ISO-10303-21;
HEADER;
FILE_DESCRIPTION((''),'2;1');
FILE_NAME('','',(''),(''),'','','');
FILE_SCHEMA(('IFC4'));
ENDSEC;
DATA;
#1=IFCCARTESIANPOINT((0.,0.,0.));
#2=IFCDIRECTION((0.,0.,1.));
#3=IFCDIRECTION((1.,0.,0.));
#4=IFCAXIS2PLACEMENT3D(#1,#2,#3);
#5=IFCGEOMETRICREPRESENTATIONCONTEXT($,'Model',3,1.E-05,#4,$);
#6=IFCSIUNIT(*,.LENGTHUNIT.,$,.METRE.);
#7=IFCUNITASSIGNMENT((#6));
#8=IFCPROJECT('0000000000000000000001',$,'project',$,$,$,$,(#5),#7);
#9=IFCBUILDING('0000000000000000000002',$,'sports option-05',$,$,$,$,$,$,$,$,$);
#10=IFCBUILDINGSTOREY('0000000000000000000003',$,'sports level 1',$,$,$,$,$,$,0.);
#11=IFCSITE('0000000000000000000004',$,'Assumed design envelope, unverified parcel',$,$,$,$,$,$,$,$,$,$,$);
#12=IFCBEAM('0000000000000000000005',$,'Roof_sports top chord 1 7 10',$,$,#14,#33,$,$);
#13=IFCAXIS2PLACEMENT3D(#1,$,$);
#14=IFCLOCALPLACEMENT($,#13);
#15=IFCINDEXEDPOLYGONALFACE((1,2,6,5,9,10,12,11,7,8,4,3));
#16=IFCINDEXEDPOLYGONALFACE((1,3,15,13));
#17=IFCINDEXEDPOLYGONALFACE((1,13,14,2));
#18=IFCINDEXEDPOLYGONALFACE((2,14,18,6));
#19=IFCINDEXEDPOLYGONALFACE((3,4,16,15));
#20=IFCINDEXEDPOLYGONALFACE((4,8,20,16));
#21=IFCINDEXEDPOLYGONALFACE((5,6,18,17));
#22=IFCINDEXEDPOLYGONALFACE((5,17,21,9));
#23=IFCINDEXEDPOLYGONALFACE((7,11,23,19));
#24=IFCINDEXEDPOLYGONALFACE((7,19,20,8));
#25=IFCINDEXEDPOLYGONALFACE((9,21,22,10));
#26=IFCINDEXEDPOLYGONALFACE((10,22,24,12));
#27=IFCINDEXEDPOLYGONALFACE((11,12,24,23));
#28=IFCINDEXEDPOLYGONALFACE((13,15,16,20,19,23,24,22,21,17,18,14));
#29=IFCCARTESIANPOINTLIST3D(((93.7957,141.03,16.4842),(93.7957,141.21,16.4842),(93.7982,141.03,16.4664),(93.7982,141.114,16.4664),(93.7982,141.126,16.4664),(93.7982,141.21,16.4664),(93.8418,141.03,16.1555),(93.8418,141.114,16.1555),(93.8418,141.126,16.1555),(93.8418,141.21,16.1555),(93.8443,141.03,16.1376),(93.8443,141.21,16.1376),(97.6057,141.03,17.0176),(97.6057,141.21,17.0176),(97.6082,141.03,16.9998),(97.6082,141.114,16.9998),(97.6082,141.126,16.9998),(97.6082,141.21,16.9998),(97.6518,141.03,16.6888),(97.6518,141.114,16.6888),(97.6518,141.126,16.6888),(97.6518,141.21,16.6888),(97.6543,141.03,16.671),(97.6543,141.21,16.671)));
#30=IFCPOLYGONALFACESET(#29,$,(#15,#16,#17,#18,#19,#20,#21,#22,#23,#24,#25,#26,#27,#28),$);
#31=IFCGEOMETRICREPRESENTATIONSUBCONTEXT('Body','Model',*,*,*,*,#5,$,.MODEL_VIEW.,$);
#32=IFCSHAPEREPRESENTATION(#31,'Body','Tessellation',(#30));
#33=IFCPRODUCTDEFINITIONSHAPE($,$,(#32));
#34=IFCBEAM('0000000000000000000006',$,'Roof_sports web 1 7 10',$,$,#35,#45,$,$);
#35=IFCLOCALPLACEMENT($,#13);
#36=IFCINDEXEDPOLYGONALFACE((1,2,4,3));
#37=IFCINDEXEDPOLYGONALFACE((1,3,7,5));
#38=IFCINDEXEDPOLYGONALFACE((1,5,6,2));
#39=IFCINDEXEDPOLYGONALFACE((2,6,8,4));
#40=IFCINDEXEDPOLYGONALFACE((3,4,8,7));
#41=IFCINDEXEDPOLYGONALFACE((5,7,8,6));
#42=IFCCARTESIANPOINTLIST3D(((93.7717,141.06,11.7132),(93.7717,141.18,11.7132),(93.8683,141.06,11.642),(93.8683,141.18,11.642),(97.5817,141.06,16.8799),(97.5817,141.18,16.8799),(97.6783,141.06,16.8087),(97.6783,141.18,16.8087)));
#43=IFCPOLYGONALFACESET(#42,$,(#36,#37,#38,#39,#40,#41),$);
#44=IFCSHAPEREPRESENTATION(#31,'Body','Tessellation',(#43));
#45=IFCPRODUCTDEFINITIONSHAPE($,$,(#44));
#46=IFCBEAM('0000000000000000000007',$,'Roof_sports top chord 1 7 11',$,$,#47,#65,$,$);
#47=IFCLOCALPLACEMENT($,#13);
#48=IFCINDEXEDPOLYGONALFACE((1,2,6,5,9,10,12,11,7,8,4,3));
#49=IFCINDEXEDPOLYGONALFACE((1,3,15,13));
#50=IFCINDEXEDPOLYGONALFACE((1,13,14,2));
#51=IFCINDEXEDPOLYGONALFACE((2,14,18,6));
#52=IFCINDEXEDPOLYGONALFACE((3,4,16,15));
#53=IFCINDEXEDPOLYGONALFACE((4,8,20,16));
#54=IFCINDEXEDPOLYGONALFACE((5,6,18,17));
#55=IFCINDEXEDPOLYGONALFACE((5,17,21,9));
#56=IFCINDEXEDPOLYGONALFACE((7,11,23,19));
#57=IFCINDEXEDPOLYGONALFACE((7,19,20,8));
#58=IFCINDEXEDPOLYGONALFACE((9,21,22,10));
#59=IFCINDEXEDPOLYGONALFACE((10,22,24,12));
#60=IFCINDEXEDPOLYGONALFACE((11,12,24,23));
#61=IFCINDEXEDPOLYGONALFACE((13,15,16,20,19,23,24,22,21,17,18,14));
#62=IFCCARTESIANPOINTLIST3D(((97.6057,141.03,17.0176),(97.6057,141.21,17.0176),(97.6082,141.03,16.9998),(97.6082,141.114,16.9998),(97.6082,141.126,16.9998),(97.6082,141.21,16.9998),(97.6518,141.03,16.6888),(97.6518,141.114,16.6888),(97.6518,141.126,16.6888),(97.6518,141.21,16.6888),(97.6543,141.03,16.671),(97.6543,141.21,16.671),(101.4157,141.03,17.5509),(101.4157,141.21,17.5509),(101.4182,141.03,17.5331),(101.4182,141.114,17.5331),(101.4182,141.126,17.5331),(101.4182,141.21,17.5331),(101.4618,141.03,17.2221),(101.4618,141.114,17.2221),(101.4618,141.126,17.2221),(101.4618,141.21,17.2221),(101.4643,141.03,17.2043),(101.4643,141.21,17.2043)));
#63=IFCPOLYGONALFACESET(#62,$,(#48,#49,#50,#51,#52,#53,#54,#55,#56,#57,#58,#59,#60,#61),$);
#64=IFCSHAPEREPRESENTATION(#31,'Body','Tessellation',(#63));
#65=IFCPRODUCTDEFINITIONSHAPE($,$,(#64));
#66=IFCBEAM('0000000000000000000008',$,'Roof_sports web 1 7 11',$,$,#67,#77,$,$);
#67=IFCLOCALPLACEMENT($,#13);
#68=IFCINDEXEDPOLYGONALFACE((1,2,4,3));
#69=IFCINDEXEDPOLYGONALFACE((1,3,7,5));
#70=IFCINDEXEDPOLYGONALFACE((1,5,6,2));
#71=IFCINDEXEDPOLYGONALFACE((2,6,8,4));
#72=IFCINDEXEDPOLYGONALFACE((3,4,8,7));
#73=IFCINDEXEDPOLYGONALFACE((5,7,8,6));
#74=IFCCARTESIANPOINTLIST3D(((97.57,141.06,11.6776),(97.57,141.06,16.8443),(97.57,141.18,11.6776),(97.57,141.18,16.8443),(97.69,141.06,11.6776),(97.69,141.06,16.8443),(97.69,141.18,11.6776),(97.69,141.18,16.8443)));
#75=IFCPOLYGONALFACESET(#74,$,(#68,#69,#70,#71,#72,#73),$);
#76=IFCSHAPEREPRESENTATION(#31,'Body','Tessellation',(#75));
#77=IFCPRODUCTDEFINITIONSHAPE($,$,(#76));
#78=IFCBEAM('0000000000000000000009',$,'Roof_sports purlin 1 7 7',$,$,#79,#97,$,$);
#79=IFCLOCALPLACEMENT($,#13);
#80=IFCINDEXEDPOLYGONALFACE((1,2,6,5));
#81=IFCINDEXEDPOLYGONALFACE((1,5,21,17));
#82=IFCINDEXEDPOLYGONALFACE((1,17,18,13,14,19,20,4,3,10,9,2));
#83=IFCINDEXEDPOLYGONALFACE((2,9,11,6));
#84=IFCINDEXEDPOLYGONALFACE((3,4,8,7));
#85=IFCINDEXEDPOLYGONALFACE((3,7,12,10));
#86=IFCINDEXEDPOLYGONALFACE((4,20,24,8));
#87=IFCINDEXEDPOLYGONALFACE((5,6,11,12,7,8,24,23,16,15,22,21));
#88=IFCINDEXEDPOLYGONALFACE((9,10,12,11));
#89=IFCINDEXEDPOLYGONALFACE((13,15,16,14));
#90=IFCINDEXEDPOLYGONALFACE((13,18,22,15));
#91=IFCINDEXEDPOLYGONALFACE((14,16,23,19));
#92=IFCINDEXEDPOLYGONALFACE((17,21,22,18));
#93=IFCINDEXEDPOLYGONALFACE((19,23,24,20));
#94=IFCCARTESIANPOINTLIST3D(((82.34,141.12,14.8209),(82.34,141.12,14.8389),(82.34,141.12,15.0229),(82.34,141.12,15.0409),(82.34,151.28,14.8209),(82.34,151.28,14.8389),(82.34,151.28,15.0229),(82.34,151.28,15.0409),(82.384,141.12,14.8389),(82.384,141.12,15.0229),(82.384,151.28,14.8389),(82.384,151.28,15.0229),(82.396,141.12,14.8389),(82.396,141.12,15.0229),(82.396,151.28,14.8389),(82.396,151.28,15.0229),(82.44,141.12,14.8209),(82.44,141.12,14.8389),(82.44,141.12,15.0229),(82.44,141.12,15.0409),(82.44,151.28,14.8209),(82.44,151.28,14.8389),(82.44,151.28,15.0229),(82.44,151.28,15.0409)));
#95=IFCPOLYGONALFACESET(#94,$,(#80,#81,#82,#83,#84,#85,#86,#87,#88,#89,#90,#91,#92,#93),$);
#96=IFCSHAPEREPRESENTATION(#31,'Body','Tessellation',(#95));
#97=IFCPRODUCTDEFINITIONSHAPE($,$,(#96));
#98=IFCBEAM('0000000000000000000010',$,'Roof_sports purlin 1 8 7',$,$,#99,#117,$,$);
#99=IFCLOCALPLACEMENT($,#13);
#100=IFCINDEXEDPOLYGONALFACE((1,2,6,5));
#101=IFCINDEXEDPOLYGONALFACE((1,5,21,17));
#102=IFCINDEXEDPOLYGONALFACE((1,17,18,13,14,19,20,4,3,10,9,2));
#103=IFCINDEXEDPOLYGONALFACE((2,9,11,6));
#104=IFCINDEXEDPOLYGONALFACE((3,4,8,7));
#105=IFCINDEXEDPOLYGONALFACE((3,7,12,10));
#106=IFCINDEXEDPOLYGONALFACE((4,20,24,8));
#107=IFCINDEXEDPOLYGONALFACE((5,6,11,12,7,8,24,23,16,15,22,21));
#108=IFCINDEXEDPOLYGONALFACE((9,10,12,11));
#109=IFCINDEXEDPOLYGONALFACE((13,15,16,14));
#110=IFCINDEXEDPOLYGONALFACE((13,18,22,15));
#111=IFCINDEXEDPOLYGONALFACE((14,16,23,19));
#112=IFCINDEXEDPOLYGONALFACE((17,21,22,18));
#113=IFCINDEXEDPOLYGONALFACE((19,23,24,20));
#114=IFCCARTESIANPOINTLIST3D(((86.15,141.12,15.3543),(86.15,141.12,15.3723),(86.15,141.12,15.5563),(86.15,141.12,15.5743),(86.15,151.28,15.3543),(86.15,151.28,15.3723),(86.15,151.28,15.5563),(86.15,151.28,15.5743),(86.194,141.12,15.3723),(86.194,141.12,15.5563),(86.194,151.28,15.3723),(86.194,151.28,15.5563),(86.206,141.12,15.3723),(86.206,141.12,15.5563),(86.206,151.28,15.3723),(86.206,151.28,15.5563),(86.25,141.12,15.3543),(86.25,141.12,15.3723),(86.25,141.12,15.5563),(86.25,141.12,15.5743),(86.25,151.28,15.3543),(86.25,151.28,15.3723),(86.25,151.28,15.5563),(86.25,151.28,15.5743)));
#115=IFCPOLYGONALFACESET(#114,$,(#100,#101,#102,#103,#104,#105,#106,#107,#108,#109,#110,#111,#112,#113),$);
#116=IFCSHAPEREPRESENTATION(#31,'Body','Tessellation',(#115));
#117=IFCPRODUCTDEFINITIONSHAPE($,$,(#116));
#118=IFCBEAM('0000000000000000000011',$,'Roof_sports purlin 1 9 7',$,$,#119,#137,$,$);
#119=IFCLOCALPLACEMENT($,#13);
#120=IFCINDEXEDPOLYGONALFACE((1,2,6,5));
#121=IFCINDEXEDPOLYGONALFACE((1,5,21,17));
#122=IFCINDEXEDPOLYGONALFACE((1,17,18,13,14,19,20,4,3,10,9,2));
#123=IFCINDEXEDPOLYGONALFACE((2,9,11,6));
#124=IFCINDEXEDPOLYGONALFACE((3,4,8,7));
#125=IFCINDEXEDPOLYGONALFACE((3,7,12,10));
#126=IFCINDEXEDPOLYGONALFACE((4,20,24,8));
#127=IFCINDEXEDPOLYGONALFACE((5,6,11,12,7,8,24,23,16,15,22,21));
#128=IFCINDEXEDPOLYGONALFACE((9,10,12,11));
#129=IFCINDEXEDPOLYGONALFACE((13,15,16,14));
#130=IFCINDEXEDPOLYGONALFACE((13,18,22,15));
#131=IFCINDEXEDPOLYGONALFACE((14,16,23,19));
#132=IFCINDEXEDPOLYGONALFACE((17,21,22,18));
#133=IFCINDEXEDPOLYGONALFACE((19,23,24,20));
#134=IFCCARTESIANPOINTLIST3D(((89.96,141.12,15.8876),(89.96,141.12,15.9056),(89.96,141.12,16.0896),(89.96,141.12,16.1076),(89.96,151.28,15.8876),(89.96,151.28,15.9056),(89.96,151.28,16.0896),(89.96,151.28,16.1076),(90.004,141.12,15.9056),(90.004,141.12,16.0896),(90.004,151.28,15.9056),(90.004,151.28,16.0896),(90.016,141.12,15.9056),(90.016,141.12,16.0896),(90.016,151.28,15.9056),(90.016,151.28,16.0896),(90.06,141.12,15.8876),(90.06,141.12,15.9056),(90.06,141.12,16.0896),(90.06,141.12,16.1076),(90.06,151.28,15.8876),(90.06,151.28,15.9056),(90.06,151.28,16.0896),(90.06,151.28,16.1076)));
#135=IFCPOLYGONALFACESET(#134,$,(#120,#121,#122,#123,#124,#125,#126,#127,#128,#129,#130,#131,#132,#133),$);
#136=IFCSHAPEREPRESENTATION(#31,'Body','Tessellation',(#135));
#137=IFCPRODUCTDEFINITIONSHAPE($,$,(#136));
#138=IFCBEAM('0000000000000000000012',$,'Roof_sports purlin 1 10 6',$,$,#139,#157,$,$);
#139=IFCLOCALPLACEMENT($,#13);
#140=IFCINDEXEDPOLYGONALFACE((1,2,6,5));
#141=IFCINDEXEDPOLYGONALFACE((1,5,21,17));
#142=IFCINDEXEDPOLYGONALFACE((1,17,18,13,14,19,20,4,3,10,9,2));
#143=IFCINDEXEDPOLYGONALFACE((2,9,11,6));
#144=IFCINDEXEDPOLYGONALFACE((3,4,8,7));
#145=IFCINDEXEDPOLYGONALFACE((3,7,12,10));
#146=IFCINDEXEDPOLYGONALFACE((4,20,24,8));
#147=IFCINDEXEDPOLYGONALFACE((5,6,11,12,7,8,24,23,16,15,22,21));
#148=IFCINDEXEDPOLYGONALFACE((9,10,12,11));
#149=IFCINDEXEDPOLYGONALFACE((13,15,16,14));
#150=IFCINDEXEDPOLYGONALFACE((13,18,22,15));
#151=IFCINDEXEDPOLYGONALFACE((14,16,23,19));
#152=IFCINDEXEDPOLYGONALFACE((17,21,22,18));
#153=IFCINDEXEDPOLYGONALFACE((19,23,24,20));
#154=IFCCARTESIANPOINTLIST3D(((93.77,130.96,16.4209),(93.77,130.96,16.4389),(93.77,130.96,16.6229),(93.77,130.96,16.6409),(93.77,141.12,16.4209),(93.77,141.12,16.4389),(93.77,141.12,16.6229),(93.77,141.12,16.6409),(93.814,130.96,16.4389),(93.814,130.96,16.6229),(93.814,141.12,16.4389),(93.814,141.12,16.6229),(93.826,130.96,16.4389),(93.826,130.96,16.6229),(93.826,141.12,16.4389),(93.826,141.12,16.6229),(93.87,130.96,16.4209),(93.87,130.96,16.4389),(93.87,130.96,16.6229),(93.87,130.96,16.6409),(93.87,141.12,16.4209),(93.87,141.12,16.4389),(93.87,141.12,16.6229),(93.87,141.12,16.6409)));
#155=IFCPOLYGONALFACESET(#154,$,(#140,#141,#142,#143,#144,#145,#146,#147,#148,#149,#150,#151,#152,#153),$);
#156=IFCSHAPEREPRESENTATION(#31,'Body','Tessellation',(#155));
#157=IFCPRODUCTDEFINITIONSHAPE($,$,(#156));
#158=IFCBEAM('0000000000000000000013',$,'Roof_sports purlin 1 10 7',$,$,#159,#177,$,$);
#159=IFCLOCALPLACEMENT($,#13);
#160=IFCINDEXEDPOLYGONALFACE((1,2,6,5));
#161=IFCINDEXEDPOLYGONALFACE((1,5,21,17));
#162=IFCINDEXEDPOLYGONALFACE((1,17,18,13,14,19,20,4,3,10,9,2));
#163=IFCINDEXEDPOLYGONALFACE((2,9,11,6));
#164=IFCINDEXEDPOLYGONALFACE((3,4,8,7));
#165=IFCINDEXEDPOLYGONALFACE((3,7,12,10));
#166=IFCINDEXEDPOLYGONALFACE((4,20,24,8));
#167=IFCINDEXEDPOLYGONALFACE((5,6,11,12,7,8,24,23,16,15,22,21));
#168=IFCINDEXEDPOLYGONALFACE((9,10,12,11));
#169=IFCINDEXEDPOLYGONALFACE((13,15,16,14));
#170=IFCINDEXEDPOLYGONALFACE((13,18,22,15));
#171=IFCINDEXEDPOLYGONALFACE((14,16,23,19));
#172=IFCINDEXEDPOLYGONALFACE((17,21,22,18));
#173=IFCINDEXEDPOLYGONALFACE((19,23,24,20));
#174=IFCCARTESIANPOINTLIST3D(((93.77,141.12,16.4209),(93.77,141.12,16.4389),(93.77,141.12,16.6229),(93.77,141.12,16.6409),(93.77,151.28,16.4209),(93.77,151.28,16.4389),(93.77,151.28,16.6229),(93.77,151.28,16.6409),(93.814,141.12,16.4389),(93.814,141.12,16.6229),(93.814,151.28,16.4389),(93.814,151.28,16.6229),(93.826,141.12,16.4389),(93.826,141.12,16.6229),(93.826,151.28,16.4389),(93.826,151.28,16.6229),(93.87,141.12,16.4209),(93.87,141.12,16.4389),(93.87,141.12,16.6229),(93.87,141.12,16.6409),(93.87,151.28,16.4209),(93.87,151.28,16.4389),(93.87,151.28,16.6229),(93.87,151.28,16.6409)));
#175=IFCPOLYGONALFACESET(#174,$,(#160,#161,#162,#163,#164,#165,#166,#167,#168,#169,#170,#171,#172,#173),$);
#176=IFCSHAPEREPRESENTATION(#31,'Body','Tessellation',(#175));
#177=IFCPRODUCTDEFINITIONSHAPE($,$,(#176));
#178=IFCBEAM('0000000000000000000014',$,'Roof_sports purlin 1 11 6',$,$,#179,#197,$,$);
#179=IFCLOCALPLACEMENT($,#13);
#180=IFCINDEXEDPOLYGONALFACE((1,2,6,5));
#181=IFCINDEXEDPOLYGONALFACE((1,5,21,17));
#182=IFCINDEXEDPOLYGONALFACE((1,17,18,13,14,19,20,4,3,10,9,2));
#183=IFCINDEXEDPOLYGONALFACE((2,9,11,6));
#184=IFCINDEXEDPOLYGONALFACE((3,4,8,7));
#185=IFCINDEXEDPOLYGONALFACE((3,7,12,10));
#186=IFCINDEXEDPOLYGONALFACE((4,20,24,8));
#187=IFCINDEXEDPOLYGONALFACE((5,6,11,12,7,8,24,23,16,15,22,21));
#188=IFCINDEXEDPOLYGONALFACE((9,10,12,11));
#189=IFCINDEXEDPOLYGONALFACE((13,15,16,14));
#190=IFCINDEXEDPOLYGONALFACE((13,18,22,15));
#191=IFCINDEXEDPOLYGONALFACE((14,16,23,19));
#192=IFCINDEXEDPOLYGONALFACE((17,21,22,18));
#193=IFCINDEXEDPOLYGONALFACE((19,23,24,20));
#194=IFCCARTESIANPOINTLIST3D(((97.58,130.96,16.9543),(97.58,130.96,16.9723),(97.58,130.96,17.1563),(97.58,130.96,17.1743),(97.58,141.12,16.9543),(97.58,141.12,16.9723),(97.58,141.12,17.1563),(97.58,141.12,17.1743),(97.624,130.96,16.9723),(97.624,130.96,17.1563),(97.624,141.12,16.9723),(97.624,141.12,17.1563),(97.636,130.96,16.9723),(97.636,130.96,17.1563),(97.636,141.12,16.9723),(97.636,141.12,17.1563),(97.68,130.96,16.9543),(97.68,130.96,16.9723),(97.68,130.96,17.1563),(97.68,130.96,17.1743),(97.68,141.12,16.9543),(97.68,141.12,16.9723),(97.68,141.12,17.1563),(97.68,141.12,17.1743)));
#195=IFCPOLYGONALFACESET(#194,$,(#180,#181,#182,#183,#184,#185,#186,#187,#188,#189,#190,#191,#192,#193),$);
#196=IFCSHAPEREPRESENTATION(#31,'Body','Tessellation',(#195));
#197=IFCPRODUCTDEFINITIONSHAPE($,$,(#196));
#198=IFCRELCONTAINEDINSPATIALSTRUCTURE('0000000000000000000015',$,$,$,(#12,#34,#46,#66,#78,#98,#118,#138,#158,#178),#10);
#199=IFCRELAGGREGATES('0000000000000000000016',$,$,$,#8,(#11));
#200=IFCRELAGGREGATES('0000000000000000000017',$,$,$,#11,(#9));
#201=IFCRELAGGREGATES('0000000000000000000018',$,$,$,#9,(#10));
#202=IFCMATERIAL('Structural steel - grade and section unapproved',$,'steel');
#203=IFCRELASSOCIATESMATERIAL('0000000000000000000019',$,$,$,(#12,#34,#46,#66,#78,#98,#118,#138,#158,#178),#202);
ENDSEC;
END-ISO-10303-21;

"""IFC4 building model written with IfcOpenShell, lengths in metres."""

from ifc_helpers import new_model, si_unit, frame, origin_with_axes, place, context, subcontext, project, spatial, rectangle, i_section, extrude, material, element, save


model = new_model("IFC4")

# Units and contexts
model_context = context("Model", 3, precision=1e-05, world=origin_with_axes())
body_context = subcontext(model_context, "Body", "Model", "MODEL_VIEW")
ifc_project = project(units=[si_unit("LENGTHUNIT", "METRE")], contexts=[model_context])

# Site, building, storey
site = spatial("IfcSite", under=ifc_project, Name="Assumed design envelope, unverified parcel")
building = spatial("IfcBuilding", under=site, Name="sports option-05")
storey = spatial("IfcBuildingStorey", under=building, Name="sports level 1", Elevation=0.0)

# Shared definitions
ifc_material_1 = material(Name="Structural steel - grade and section unapproved", Category="steel")

# Beams
beam_1_placement = place(None, frame((93.82, 141.12, 16.3109), z_axis=(0.990344, 0.0, 0.138631), x_axis=(0.0, 1.0, 0.0)))
element("IfcBeam", 1, at=beam_1_placement, inside=storey, material=ifc_material_1, Name="Roof_sports top chord 1 7 10", context=body_context, shape_type="SweptSolid", body=[
    extrude(i_section(OverallWidth=0.18, OverallDepth=0.35, WebThickness=0.012, FlangeThickness=0.018, FilletRadius=0.0), origin_with_axes(), (0.0, 0.0, 1.0), 3.8471),
])
beam_2_placement = place(None, frame((93.82, 141.12, 11.6776), z_axis=(0.5935, 0.0, 0.804834), x_axis=(0.0, 1.0, 0.0)))
element("IfcBeam", 2, at=beam_2_placement, inside=storey, material=ifc_material_1, Name="Roof_sports web 1 7 10", context=body_context, shape_type="SweptSolid", body=[
    extrude(rectangle(XDim=0.12, YDim=0.12), origin_with_axes(), (0.0, 0.0, 1.0), 6.4195),
])
beam_3_placement = place(None, frame((97.63, 141.12, 16.8443), z_axis=(0.990344, 0.0, 0.138631), x_axis=(0.0, 1.0, 0.0)))
element("IfcBeam", 3, at=beam_3_placement, inside=storey, material=ifc_material_1, Name="Roof_sports top chord 1 7 11", context=body_context, shape_type="SweptSolid", body=[
    extrude(i_section(OverallWidth=0.18, OverallDepth=0.35, WebThickness=0.012, FlangeThickness=0.018, FilletRadius=0.0), origin_with_axes(), (0.0, 0.0, 1.0), 3.8472),
])
beam_4_placement = place(None, frame((97.63, 141.12, 11.6776), z_axis=(0.0, 0.0, 1.0), x_axis=(-1.0, 0.0, 0.0)))
element("IfcBeam", 4, at=beam_4_placement, inside=storey, material=ifc_material_1, Name="Roof_sports web 1 7 11", context=body_context, shape_type="SweptSolid", body=[
    extrude(rectangle(XDim=0.12, YDim=0.12), origin_with_axes(), (0.0, 0.0, 1.0), 5.1667),
])
for number, where, z_axis, x_axis, name in (
    (5, (82.39, 141.12, 14.9309), (0.0, 1.0, 0.0), (-1.0, 0.0, 0.0), "Roof_sports purlin 1 7 7"),
    (6, (86.2, 141.12, 15.4643), (0.0, 1.0, 0.0), (-1.0, 0.0, 0.0), "Roof_sports purlin 1 8 7"),
    (7, (90.01, 141.12, 15.9976), (0.0, 1.0, 0.0), (-1.0, 0.0, 0.0), "Roof_sports purlin 1 9 7"),
):
    element("IfcBeam", number, at=place(None, frame(where, z_axis=z_axis, x_axis=x_axis)), inside=storey, material=ifc_material_1, Name=name, context=body_context, shape_type="SweptSolid", body=[
        extrude(i_section(OverallWidth=0.1, OverallDepth=0.22, WebThickness=0.012, FlangeThickness=0.018, FilletRadius=0.0), origin_with_axes(), (0.0, 0.0, 1.0), 10.16),
    ])
beam_5_placement = place(None, frame((93.82, 130.96, 16.5309), z_axis=(0.0, 1.0, 0.0), x_axis=(-1.0, 0.0, 0.0)))
element("IfcBeam", 8, at=beam_5_placement, inside=storey, material=ifc_material_1, Name="Roof_sports purlin 1 10 6", context=body_context, shape_type="SweptSolid", body=[
    extrude(i_section(OverallWidth=0.1, OverallDepth=0.22, WebThickness=0.012, FlangeThickness=0.018, FilletRadius=0.0), origin_with_axes(), (0.0, 0.0, 1.0), 10.16),
])
beam_6_placement = place(None, frame((93.82, 141.12, 16.5309), z_axis=(0.0, 1.0, 0.0), x_axis=(-1.0, 0.0, 0.0)))
element("IfcBeam", 9, at=beam_6_placement, inside=storey, material=ifc_material_1, Name="Roof_sports purlin 1 10 7", context=body_context, shape_type="SweptSolid", body=[
    extrude(i_section(OverallWidth=0.1, OverallDepth=0.22, WebThickness=0.012, FlangeThickness=0.018, FilletRadius=0.0), origin_with_axes(), (0.0, 0.0, 1.0), 10.16),
])
beam_7_placement = place(None, frame((97.63, 130.96, 17.0643), z_axis=(0.0, 1.0, 0.0), x_axis=(-1.0, 0.0, 0.0)))
element("IfcBeam", 10, at=beam_7_placement, inside=storey, material=ifc_material_1, Name="Roof_sports purlin 1 11 6", context=body_context, shape_type="SweptSolid", body=[
    extrude(i_section(OverallWidth=0.1, OverallDepth=0.22, WebThickness=0.012, FlangeThickness=0.018, FilletRadius=0.0), origin_with_axes(), (0.0, 0.0, 1.0), 10.16),
])

save(model, "model.ifc")
